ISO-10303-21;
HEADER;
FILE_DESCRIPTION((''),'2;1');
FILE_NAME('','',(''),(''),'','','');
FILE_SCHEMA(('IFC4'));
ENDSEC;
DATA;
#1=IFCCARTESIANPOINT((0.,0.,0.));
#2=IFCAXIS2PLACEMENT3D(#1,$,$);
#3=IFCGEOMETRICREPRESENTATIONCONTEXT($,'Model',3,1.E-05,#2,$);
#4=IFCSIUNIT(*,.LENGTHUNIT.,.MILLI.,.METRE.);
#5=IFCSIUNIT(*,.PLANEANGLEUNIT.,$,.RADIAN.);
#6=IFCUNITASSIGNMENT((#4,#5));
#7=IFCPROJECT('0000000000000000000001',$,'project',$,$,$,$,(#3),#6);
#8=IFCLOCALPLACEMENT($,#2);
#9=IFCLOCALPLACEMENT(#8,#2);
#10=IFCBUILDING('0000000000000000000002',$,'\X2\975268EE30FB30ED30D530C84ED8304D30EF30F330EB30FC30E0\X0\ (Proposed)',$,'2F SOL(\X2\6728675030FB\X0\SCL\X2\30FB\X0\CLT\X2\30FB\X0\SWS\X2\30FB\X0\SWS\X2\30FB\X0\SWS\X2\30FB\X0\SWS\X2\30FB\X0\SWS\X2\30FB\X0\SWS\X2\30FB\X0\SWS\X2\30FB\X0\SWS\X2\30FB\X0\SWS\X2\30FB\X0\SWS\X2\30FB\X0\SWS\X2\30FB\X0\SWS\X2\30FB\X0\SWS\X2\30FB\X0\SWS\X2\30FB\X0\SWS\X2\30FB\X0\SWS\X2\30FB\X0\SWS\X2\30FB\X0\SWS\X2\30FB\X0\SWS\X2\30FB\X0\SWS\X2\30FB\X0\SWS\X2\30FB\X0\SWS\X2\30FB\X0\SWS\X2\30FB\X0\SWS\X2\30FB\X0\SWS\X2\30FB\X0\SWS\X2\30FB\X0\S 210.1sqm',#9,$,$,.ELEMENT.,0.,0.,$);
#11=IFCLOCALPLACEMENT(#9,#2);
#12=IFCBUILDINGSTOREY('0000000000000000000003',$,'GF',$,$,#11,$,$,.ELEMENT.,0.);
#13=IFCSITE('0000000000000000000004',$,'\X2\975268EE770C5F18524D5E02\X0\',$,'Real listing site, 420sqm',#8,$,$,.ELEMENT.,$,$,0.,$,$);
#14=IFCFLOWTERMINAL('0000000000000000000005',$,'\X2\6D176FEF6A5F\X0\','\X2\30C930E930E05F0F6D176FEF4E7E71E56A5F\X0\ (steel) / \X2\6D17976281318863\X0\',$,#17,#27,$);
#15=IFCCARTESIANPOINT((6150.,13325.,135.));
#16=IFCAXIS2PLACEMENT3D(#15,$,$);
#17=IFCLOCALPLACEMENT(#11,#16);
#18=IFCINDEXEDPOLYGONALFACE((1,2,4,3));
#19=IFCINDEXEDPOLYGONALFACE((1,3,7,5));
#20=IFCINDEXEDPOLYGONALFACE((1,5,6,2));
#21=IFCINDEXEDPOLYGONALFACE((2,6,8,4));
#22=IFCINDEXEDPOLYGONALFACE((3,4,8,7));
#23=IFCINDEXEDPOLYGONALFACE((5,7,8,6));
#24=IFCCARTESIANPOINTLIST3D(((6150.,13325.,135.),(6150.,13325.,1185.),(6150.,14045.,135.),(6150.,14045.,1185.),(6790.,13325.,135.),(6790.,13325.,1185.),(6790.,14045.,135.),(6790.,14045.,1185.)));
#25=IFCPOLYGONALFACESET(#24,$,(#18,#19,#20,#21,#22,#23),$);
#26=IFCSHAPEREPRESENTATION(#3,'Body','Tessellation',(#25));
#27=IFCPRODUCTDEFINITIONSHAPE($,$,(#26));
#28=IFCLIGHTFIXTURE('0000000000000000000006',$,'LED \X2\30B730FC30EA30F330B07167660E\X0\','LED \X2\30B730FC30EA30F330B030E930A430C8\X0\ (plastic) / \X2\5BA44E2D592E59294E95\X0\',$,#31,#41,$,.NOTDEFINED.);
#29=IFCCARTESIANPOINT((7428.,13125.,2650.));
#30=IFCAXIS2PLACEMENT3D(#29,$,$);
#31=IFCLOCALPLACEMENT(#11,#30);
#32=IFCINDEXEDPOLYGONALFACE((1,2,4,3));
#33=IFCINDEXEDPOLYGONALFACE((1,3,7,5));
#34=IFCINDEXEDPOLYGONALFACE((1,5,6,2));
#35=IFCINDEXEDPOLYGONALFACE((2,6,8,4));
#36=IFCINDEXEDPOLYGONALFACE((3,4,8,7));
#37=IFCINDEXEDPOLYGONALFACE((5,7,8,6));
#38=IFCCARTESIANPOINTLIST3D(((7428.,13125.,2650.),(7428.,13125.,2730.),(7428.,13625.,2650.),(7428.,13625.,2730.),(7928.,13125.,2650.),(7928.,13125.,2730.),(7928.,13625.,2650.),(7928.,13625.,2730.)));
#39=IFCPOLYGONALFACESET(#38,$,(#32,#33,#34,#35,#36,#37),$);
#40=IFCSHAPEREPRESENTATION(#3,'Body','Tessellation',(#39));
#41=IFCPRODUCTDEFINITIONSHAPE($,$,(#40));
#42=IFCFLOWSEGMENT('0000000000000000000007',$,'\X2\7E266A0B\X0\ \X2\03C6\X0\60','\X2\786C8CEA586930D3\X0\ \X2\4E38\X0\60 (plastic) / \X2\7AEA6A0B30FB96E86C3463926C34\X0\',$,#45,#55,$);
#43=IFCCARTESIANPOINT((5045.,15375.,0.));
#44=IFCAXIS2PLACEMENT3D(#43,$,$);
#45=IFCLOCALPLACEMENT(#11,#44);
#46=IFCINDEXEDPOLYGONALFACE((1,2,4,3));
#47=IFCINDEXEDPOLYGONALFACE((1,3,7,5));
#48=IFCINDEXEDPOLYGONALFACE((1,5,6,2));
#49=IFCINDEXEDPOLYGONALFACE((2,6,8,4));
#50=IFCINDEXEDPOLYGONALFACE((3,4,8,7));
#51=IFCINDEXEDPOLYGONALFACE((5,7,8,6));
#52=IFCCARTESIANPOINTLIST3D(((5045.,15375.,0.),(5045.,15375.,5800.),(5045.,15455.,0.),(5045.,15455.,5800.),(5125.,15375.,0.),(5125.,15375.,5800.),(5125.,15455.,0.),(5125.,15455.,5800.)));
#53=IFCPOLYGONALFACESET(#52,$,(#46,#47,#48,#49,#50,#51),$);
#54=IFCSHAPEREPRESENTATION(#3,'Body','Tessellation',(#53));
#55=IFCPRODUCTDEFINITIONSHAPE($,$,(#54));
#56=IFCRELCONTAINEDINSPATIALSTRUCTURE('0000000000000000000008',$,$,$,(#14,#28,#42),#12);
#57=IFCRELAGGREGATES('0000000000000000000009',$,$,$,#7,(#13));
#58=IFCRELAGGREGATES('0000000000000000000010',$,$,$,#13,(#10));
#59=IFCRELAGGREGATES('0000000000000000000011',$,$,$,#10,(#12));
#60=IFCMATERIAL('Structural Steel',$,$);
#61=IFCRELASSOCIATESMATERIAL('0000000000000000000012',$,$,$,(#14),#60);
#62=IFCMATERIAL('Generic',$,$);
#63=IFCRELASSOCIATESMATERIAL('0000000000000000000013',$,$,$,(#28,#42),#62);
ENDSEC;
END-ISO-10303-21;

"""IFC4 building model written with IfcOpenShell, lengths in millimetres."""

from ifc_helpers import new_model, si_unit, frame, frame_2d, origin, place, context, project, spatial, rectangle, extrude, material, element, save


model = new_model("IFC4")

# Units and contexts
model_context = context("Model", 3, precision=1e-05, world=origin())
ifc_project = project(units=[si_unit("LENGTHUNIT", "METRE", prefix="MILLI"), si_unit("PLANEANGLEUNIT", "RADIAN")], contexts=[model_context])

# Site, building, storey
site_placement = place(None, origin())
site = spatial("IfcSite", under=ifc_project, at=site_placement, Name="青森県弘前市", ObjectType="Real listing site, 420sqm", CompositionType="ELEMENT", RefElevation=0.0)
building_placement = place(site_placement, origin())
building = spatial("IfcBuilding", under=site, at=building_placement, Name="青森・ロフト付きワンルーム (Proposed)", ObjectType="2F SOL(木材・SCL・CLT・SWS・SWS・SWS・SWS・SWS・SWS・SWS・SWS・SWS・SWS・SWS・SWS・SWS・SWS・SWS・SWS・SWS・SWS・SWS・SWS・SWS・SWS・SWS・SWS・SWS・SWS・S 210.1sqm", CompositionType="ELEMENT", ElevationOfRefHeight=0.0, ElevationOfTerrain=0.0)
storey_placement = place(building_placement, origin())
storey = spatial("IfcBuildingStorey", under=building, at=storey_placement, Name="GF", CompositionType="ELEMENT", Elevation=0.0)

# Flow terminal
ifc_material_1 = material(Name="Structural Steel")
flow_terminal_placement = place(storey_placement, frame((6150.0, 13325.0, 135.0)))
element("IfcFlowTerminal", 1, at=flow_terminal_placement, inside=storey, material=ifc_material_1, Name="洗濯機", Description="ドラム式洗濯乾燥機 (steel) / 洗面脱衣", context=model_context, shape_type="SweptSolid", body=[
    extrude(rectangle(XDim=640.0, YDim=720.0, at=frame_2d((320.0, 360.0))), frame((6150.0, 13325.0, 135.0)), (0.0, 0.0, 1.0), 1050.0),
])

# Light fixture
ifc_material_2 = material(Name="Generic")
light_fixture_placement = place(storey_placement, frame((7428.0, 13125.0, 2650.0)))
element("IfcLightFixture", 2, at=light_fixture_placement, inside=storey, material=ifc_material_2, Name="LED シーリング照明", Description="LED シーリングライト (plastic) / 室中央天井", PredefinedType="NOTDEFINED", context=model_context, shape_type="SweptSolid", body=[
    extrude(rectangle(XDim=500.0, YDim=500.0, at=frame_2d((250.0, 250.0))), frame((7428.0, 13125.0, 2650.0)), (0.0, 0.0, 1.0), 80.0),
])

# Flow segment
flow_segment_1_placement = place(storey_placement, frame((5045.0, 15375.0, 0.0)))
element("IfcFlowSegment", 3, at=flow_segment_1_placement, inside=storey, material=ifc_material_2, Name="縦樋 φ60", Description="硬質塩ビ 丸60 (plastic) / 竪樋・雨水排水", context=model_context, shape_type="SweptSolid", body=[
    extrude(rectangle(XDim=80.0, YDim=80.0, at=frame_2d((40.0, 40.0))), frame((5045.0, 15375.0, 0.0)), (0.0, 0.0, 1.0), 5800.0),
])

save(model, "model.ifc")
